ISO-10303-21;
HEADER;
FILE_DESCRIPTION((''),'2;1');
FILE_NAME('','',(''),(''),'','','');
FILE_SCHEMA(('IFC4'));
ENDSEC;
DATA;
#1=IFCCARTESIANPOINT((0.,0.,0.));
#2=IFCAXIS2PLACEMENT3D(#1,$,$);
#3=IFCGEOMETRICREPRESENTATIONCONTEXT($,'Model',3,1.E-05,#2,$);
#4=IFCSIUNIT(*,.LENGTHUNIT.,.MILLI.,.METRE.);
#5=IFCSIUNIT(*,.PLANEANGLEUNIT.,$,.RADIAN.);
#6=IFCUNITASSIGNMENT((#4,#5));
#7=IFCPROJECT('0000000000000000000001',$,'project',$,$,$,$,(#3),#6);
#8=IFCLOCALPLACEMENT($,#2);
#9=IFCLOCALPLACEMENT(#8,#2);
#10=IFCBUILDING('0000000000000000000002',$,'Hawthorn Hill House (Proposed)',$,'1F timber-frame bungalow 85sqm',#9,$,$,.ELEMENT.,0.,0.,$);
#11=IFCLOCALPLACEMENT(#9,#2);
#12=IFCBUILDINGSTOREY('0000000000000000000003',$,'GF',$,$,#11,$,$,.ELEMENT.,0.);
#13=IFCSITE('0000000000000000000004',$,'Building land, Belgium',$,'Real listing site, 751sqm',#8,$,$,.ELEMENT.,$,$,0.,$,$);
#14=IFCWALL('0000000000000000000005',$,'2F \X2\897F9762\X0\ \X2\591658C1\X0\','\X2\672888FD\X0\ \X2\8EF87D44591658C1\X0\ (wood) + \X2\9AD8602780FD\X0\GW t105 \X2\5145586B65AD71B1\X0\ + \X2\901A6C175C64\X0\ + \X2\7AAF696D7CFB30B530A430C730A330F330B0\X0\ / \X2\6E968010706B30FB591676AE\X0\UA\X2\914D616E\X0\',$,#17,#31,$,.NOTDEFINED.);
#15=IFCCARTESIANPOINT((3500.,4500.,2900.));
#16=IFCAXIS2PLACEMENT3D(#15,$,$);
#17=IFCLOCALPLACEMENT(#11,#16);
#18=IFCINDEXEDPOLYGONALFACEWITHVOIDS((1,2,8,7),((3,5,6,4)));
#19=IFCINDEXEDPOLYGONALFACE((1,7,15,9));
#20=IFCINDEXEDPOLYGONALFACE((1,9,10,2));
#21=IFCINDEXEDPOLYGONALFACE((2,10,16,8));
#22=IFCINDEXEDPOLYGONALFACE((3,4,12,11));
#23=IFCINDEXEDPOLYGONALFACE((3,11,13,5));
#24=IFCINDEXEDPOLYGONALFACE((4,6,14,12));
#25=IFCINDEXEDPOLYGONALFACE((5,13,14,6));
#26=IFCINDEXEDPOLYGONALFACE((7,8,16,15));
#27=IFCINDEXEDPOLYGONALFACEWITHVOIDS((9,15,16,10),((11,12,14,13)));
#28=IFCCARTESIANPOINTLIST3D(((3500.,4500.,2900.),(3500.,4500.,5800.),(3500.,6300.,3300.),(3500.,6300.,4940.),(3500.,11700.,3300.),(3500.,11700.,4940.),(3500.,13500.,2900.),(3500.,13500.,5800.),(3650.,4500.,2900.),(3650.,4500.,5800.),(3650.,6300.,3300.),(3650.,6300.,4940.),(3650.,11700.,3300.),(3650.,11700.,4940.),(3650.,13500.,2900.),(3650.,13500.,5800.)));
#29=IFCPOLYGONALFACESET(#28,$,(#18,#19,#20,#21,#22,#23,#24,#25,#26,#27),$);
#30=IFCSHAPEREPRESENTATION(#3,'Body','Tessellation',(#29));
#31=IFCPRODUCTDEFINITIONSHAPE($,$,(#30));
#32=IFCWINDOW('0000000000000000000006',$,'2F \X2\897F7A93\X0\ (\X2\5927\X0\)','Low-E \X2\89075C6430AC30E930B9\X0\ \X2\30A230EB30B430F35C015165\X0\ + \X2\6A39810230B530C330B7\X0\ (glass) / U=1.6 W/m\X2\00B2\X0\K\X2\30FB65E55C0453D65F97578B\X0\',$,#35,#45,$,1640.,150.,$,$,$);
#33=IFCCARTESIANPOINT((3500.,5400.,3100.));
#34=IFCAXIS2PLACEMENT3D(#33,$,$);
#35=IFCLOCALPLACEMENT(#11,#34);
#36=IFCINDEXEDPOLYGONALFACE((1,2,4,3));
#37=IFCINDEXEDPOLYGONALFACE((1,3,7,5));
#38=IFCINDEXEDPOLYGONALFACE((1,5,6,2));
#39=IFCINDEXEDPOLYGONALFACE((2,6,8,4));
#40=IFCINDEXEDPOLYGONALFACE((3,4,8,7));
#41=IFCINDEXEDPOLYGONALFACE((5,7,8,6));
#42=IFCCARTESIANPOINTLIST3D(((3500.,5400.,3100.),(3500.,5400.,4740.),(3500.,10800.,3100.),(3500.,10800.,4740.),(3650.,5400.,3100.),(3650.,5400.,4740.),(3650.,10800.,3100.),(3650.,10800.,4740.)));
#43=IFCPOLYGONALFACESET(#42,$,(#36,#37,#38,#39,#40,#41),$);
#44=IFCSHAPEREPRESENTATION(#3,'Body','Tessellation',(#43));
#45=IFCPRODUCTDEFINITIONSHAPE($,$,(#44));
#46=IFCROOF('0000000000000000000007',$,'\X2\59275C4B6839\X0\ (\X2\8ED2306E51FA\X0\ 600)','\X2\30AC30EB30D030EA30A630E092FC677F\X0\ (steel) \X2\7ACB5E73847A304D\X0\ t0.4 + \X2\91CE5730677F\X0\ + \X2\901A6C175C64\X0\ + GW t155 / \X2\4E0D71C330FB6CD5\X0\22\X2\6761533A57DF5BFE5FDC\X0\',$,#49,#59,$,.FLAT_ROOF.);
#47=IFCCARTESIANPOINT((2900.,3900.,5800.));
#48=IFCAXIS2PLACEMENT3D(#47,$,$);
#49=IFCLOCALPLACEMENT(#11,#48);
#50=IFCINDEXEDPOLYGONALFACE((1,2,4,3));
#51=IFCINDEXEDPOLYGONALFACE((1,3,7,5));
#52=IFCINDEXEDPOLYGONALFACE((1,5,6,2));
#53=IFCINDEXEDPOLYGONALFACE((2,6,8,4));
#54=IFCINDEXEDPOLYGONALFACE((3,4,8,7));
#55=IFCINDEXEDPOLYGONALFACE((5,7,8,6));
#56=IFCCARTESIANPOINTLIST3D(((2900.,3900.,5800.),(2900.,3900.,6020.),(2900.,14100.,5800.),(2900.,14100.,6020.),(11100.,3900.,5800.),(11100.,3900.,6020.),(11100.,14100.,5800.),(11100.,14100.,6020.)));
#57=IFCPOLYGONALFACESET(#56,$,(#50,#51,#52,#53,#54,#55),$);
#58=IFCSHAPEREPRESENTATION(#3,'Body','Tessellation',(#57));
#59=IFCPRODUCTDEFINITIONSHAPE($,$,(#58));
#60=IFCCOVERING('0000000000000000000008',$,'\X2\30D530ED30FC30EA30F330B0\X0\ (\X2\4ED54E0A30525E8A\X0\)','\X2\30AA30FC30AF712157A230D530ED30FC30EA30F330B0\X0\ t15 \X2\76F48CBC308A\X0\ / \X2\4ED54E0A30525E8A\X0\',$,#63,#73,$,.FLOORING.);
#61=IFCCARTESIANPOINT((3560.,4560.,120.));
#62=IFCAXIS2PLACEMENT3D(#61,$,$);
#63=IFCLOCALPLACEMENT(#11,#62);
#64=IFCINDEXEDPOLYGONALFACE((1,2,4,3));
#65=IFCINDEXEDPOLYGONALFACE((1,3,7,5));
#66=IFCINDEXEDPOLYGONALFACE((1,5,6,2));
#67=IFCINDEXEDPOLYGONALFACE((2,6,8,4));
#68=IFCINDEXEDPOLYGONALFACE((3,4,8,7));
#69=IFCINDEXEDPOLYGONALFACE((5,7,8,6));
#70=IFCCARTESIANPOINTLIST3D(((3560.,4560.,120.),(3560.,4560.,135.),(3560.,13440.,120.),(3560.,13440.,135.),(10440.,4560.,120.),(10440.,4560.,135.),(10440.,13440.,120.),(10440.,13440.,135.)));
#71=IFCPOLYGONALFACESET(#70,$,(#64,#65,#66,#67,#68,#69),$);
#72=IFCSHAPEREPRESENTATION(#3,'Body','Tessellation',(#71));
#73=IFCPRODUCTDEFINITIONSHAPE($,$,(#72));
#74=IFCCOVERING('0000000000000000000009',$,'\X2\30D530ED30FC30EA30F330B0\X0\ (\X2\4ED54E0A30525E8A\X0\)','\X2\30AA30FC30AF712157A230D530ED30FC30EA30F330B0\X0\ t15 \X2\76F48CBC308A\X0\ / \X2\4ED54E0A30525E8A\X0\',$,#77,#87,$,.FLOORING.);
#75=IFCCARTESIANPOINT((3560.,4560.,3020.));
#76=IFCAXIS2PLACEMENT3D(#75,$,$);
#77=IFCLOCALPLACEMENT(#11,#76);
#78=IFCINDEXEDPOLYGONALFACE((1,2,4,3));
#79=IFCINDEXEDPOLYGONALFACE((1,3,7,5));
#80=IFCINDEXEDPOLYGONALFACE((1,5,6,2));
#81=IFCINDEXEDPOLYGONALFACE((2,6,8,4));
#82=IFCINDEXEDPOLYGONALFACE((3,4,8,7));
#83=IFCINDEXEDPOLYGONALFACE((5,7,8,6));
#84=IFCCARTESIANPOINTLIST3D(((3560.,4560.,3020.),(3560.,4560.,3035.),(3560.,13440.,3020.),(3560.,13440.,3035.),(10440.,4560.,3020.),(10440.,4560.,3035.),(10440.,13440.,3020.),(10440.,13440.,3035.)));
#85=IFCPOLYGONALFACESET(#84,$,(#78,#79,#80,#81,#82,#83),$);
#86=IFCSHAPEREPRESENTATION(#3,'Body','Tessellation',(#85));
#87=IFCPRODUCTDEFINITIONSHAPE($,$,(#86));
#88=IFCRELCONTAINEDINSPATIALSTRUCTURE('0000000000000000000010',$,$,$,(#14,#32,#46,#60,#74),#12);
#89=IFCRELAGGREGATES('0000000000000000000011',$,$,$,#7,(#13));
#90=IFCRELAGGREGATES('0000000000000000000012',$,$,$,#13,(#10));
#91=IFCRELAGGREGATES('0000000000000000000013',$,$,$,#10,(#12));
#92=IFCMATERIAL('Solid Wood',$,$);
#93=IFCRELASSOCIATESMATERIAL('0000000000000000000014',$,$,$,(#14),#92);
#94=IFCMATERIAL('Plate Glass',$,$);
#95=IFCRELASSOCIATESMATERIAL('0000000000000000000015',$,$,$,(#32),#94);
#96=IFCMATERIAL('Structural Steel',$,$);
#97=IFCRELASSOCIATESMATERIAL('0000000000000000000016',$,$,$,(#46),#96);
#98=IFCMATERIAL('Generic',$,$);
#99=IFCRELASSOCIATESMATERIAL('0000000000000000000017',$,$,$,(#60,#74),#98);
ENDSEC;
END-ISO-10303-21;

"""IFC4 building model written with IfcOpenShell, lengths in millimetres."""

from ifc_helpers import new_model, si_unit, frame, frame_2d, origin, place, context, project, spatial, rectangle, extrude, material, element, fill, save


model = new_model("IFC4")

# Units and contexts
model_context = context("Model", 3, precision=1e-05, world=origin())
ifc_project = project(units=[si_unit("LENGTHUNIT", "METRE", prefix="MILLI"), si_unit("PLANEANGLEUNIT", "RADIAN")], contexts=[model_context])

# Site, building, storey
site_placement = place(None, origin())
site = spatial("IfcSite", under=ifc_project, at=site_placement, Name="Building land, Belgium", ObjectType="Real listing site, 751sqm", CompositionType="ELEMENT", RefElevation=0.0)
building_placement = place(site_placement, origin())
building = spatial("IfcBuilding", under=site, at=building_placement, Name="Hawthorn Hill House (Proposed)", ObjectType="1F timber-frame bungalow 85sqm", CompositionType="ELEMENT", ElevationOfRefHeight=0.0, ElevationOfTerrain=0.0)
storey_placement = place(building_placement, origin())
storey = spatial("IfcBuildingStorey", under=building, at=storey_placement, Name="GF", CompositionType="ELEMENT", Elevation=0.0)

# Shared definitions
ifc_material_1 = material(Name="Solid Wood")
ifc_material_2 = material(Name="Generic")

# Shared definitions
ifc_material_3 = material(Name="Plate Glass")

# Wall, opening, window
wall_1_placement = place(storey_placement, frame((3500.0, 4500.0, 2900.0)))
wall_1 = element("IfcWall", 1, at=wall_1_placement, inside=storey, material=ifc_material_1, Name="2F 西面 外壁", Description="木製 軸組外壁 (wood) + 高性能GW t105 充填断熱 + 通気層 + 窯業系サイディング / 準耐火・外皮UA配慮", PredefinedType="NOTDEFINED", context=model_context, shape_type="SweptSolid", body=[
    extrude(rectangle(XDim=150.0, YDim=9000.0, at=frame_2d((75.0, 4500.0))), frame((3500.0, 4500.0, 2900.0)), (0.0, 0.0, 1.0), 2900.0),
])
opening_1_placement = place(storey_placement, frame((3500.0, 5400.0, 3100.0)))
opening_1 = element("IfcOpeningElement", 2, at=opening_1_placement, cuts=wall_1, PredefinedType="NOTDEFINED", context=model_context, shape_type="SweptSolid", body=[
    extrude(rectangle(XDim=150.0, YDim=5400.0, at=frame_2d((75.0, 2700.0))), frame((3500.0, 5400.0, 3100.0)), (0.0, 0.0, 1.0), 1640.0),
])
window_1_placement = place(storey_placement, frame((3500.0, 5400.0, 3100.0)))
window_1 = element("IfcWindow", 3, at=window_1_placement, inside=storey, material=ifc_material_3, Name="2F 西窓 (大)", Description="Low-E 複層ガラス アルゴン封入 + 樹脂サッシ (glass) / U=1.6 W/m²K・日射取得型", OverallHeight=1640.0, OverallWidth=150.0, context=model_context, shape_type="SweptSolid", body=[
    extrude(rectangle(XDim=150.0, YDim=5400.0, at=frame_2d((75.0, 2700.0))), frame((3500.0, 5400.0, 3100.0)), (0.0, 0.0, 1.0), 1640.0),
])
fill(opening_1, window_1)

# Roof
ifc_material_4 = material(Name="Structural Steel")
roof_placement = place(storey_placement, frame((2900.0, 3900.0, 5800.0)))
element("IfcRoof", 4, at=roof_placement, inside=storey, material=ifc_material_4, Name="大屋根 (軒の出 600)", Description="ガルバリウム鋼板 (steel) 立平葺き t0.4 + 野地板 + 通気層 + GW t155 / 不燃・法22条区域対応", PredefinedType="FLAT_ROOF", context=model_context, shape_type="SweptSolid", body=[
    extrude(rectangle(XDim=8200.0, YDim=10200.0, at=frame_2d((4100.0, 5100.0))), frame((2900.0, 3900.0, 5800.0)), (0.0, 0.0, 1.0), 220.0),
])

# Coverings
covering_1_placement = place(storey_placement, frame((3560.0, 4560.0, 120.0)))
element("IfcCovering", 5, at=covering_1_placement, inside=storey, material=ifc_material_2, Name="フローリング (仕上げ床)", Description="オーク無垢フローリング t15 直貼り / 仕上げ床", PredefinedType="FLOORING", context=model_context, shape_type="SweptSolid", body=[
    extrude(rectangle(XDim=6880.0, YDim=8880.0, at=frame_2d((3440.0, 4440.0))), frame((3560.0, 4560.0, 120.0)), (0.0, 0.0, 1.0), 15.0),
])
covering_2_placement = place(storey_placement, frame((3560.0, 4560.0, 3020.0)))
element("IfcCovering", 6, at=covering_2_placement, inside=storey, material=ifc_material_2, Name="フローリング (仕上げ床)", Description="オーク無垢フローリング t15 直貼り / 仕上げ床", PredefinedType="FLOORING", context=model_context, shape_type="SweptSolid", body=[
    extrude(rectangle(XDim=6880.0, YDim=8880.0, at=frame_2d((3440.0, 4440.0))), frame((3560.0, 4560.0, 3020.0)), (0.0, 0.0, 1.0), 15.0),
])

save(model, "model.ifc")
